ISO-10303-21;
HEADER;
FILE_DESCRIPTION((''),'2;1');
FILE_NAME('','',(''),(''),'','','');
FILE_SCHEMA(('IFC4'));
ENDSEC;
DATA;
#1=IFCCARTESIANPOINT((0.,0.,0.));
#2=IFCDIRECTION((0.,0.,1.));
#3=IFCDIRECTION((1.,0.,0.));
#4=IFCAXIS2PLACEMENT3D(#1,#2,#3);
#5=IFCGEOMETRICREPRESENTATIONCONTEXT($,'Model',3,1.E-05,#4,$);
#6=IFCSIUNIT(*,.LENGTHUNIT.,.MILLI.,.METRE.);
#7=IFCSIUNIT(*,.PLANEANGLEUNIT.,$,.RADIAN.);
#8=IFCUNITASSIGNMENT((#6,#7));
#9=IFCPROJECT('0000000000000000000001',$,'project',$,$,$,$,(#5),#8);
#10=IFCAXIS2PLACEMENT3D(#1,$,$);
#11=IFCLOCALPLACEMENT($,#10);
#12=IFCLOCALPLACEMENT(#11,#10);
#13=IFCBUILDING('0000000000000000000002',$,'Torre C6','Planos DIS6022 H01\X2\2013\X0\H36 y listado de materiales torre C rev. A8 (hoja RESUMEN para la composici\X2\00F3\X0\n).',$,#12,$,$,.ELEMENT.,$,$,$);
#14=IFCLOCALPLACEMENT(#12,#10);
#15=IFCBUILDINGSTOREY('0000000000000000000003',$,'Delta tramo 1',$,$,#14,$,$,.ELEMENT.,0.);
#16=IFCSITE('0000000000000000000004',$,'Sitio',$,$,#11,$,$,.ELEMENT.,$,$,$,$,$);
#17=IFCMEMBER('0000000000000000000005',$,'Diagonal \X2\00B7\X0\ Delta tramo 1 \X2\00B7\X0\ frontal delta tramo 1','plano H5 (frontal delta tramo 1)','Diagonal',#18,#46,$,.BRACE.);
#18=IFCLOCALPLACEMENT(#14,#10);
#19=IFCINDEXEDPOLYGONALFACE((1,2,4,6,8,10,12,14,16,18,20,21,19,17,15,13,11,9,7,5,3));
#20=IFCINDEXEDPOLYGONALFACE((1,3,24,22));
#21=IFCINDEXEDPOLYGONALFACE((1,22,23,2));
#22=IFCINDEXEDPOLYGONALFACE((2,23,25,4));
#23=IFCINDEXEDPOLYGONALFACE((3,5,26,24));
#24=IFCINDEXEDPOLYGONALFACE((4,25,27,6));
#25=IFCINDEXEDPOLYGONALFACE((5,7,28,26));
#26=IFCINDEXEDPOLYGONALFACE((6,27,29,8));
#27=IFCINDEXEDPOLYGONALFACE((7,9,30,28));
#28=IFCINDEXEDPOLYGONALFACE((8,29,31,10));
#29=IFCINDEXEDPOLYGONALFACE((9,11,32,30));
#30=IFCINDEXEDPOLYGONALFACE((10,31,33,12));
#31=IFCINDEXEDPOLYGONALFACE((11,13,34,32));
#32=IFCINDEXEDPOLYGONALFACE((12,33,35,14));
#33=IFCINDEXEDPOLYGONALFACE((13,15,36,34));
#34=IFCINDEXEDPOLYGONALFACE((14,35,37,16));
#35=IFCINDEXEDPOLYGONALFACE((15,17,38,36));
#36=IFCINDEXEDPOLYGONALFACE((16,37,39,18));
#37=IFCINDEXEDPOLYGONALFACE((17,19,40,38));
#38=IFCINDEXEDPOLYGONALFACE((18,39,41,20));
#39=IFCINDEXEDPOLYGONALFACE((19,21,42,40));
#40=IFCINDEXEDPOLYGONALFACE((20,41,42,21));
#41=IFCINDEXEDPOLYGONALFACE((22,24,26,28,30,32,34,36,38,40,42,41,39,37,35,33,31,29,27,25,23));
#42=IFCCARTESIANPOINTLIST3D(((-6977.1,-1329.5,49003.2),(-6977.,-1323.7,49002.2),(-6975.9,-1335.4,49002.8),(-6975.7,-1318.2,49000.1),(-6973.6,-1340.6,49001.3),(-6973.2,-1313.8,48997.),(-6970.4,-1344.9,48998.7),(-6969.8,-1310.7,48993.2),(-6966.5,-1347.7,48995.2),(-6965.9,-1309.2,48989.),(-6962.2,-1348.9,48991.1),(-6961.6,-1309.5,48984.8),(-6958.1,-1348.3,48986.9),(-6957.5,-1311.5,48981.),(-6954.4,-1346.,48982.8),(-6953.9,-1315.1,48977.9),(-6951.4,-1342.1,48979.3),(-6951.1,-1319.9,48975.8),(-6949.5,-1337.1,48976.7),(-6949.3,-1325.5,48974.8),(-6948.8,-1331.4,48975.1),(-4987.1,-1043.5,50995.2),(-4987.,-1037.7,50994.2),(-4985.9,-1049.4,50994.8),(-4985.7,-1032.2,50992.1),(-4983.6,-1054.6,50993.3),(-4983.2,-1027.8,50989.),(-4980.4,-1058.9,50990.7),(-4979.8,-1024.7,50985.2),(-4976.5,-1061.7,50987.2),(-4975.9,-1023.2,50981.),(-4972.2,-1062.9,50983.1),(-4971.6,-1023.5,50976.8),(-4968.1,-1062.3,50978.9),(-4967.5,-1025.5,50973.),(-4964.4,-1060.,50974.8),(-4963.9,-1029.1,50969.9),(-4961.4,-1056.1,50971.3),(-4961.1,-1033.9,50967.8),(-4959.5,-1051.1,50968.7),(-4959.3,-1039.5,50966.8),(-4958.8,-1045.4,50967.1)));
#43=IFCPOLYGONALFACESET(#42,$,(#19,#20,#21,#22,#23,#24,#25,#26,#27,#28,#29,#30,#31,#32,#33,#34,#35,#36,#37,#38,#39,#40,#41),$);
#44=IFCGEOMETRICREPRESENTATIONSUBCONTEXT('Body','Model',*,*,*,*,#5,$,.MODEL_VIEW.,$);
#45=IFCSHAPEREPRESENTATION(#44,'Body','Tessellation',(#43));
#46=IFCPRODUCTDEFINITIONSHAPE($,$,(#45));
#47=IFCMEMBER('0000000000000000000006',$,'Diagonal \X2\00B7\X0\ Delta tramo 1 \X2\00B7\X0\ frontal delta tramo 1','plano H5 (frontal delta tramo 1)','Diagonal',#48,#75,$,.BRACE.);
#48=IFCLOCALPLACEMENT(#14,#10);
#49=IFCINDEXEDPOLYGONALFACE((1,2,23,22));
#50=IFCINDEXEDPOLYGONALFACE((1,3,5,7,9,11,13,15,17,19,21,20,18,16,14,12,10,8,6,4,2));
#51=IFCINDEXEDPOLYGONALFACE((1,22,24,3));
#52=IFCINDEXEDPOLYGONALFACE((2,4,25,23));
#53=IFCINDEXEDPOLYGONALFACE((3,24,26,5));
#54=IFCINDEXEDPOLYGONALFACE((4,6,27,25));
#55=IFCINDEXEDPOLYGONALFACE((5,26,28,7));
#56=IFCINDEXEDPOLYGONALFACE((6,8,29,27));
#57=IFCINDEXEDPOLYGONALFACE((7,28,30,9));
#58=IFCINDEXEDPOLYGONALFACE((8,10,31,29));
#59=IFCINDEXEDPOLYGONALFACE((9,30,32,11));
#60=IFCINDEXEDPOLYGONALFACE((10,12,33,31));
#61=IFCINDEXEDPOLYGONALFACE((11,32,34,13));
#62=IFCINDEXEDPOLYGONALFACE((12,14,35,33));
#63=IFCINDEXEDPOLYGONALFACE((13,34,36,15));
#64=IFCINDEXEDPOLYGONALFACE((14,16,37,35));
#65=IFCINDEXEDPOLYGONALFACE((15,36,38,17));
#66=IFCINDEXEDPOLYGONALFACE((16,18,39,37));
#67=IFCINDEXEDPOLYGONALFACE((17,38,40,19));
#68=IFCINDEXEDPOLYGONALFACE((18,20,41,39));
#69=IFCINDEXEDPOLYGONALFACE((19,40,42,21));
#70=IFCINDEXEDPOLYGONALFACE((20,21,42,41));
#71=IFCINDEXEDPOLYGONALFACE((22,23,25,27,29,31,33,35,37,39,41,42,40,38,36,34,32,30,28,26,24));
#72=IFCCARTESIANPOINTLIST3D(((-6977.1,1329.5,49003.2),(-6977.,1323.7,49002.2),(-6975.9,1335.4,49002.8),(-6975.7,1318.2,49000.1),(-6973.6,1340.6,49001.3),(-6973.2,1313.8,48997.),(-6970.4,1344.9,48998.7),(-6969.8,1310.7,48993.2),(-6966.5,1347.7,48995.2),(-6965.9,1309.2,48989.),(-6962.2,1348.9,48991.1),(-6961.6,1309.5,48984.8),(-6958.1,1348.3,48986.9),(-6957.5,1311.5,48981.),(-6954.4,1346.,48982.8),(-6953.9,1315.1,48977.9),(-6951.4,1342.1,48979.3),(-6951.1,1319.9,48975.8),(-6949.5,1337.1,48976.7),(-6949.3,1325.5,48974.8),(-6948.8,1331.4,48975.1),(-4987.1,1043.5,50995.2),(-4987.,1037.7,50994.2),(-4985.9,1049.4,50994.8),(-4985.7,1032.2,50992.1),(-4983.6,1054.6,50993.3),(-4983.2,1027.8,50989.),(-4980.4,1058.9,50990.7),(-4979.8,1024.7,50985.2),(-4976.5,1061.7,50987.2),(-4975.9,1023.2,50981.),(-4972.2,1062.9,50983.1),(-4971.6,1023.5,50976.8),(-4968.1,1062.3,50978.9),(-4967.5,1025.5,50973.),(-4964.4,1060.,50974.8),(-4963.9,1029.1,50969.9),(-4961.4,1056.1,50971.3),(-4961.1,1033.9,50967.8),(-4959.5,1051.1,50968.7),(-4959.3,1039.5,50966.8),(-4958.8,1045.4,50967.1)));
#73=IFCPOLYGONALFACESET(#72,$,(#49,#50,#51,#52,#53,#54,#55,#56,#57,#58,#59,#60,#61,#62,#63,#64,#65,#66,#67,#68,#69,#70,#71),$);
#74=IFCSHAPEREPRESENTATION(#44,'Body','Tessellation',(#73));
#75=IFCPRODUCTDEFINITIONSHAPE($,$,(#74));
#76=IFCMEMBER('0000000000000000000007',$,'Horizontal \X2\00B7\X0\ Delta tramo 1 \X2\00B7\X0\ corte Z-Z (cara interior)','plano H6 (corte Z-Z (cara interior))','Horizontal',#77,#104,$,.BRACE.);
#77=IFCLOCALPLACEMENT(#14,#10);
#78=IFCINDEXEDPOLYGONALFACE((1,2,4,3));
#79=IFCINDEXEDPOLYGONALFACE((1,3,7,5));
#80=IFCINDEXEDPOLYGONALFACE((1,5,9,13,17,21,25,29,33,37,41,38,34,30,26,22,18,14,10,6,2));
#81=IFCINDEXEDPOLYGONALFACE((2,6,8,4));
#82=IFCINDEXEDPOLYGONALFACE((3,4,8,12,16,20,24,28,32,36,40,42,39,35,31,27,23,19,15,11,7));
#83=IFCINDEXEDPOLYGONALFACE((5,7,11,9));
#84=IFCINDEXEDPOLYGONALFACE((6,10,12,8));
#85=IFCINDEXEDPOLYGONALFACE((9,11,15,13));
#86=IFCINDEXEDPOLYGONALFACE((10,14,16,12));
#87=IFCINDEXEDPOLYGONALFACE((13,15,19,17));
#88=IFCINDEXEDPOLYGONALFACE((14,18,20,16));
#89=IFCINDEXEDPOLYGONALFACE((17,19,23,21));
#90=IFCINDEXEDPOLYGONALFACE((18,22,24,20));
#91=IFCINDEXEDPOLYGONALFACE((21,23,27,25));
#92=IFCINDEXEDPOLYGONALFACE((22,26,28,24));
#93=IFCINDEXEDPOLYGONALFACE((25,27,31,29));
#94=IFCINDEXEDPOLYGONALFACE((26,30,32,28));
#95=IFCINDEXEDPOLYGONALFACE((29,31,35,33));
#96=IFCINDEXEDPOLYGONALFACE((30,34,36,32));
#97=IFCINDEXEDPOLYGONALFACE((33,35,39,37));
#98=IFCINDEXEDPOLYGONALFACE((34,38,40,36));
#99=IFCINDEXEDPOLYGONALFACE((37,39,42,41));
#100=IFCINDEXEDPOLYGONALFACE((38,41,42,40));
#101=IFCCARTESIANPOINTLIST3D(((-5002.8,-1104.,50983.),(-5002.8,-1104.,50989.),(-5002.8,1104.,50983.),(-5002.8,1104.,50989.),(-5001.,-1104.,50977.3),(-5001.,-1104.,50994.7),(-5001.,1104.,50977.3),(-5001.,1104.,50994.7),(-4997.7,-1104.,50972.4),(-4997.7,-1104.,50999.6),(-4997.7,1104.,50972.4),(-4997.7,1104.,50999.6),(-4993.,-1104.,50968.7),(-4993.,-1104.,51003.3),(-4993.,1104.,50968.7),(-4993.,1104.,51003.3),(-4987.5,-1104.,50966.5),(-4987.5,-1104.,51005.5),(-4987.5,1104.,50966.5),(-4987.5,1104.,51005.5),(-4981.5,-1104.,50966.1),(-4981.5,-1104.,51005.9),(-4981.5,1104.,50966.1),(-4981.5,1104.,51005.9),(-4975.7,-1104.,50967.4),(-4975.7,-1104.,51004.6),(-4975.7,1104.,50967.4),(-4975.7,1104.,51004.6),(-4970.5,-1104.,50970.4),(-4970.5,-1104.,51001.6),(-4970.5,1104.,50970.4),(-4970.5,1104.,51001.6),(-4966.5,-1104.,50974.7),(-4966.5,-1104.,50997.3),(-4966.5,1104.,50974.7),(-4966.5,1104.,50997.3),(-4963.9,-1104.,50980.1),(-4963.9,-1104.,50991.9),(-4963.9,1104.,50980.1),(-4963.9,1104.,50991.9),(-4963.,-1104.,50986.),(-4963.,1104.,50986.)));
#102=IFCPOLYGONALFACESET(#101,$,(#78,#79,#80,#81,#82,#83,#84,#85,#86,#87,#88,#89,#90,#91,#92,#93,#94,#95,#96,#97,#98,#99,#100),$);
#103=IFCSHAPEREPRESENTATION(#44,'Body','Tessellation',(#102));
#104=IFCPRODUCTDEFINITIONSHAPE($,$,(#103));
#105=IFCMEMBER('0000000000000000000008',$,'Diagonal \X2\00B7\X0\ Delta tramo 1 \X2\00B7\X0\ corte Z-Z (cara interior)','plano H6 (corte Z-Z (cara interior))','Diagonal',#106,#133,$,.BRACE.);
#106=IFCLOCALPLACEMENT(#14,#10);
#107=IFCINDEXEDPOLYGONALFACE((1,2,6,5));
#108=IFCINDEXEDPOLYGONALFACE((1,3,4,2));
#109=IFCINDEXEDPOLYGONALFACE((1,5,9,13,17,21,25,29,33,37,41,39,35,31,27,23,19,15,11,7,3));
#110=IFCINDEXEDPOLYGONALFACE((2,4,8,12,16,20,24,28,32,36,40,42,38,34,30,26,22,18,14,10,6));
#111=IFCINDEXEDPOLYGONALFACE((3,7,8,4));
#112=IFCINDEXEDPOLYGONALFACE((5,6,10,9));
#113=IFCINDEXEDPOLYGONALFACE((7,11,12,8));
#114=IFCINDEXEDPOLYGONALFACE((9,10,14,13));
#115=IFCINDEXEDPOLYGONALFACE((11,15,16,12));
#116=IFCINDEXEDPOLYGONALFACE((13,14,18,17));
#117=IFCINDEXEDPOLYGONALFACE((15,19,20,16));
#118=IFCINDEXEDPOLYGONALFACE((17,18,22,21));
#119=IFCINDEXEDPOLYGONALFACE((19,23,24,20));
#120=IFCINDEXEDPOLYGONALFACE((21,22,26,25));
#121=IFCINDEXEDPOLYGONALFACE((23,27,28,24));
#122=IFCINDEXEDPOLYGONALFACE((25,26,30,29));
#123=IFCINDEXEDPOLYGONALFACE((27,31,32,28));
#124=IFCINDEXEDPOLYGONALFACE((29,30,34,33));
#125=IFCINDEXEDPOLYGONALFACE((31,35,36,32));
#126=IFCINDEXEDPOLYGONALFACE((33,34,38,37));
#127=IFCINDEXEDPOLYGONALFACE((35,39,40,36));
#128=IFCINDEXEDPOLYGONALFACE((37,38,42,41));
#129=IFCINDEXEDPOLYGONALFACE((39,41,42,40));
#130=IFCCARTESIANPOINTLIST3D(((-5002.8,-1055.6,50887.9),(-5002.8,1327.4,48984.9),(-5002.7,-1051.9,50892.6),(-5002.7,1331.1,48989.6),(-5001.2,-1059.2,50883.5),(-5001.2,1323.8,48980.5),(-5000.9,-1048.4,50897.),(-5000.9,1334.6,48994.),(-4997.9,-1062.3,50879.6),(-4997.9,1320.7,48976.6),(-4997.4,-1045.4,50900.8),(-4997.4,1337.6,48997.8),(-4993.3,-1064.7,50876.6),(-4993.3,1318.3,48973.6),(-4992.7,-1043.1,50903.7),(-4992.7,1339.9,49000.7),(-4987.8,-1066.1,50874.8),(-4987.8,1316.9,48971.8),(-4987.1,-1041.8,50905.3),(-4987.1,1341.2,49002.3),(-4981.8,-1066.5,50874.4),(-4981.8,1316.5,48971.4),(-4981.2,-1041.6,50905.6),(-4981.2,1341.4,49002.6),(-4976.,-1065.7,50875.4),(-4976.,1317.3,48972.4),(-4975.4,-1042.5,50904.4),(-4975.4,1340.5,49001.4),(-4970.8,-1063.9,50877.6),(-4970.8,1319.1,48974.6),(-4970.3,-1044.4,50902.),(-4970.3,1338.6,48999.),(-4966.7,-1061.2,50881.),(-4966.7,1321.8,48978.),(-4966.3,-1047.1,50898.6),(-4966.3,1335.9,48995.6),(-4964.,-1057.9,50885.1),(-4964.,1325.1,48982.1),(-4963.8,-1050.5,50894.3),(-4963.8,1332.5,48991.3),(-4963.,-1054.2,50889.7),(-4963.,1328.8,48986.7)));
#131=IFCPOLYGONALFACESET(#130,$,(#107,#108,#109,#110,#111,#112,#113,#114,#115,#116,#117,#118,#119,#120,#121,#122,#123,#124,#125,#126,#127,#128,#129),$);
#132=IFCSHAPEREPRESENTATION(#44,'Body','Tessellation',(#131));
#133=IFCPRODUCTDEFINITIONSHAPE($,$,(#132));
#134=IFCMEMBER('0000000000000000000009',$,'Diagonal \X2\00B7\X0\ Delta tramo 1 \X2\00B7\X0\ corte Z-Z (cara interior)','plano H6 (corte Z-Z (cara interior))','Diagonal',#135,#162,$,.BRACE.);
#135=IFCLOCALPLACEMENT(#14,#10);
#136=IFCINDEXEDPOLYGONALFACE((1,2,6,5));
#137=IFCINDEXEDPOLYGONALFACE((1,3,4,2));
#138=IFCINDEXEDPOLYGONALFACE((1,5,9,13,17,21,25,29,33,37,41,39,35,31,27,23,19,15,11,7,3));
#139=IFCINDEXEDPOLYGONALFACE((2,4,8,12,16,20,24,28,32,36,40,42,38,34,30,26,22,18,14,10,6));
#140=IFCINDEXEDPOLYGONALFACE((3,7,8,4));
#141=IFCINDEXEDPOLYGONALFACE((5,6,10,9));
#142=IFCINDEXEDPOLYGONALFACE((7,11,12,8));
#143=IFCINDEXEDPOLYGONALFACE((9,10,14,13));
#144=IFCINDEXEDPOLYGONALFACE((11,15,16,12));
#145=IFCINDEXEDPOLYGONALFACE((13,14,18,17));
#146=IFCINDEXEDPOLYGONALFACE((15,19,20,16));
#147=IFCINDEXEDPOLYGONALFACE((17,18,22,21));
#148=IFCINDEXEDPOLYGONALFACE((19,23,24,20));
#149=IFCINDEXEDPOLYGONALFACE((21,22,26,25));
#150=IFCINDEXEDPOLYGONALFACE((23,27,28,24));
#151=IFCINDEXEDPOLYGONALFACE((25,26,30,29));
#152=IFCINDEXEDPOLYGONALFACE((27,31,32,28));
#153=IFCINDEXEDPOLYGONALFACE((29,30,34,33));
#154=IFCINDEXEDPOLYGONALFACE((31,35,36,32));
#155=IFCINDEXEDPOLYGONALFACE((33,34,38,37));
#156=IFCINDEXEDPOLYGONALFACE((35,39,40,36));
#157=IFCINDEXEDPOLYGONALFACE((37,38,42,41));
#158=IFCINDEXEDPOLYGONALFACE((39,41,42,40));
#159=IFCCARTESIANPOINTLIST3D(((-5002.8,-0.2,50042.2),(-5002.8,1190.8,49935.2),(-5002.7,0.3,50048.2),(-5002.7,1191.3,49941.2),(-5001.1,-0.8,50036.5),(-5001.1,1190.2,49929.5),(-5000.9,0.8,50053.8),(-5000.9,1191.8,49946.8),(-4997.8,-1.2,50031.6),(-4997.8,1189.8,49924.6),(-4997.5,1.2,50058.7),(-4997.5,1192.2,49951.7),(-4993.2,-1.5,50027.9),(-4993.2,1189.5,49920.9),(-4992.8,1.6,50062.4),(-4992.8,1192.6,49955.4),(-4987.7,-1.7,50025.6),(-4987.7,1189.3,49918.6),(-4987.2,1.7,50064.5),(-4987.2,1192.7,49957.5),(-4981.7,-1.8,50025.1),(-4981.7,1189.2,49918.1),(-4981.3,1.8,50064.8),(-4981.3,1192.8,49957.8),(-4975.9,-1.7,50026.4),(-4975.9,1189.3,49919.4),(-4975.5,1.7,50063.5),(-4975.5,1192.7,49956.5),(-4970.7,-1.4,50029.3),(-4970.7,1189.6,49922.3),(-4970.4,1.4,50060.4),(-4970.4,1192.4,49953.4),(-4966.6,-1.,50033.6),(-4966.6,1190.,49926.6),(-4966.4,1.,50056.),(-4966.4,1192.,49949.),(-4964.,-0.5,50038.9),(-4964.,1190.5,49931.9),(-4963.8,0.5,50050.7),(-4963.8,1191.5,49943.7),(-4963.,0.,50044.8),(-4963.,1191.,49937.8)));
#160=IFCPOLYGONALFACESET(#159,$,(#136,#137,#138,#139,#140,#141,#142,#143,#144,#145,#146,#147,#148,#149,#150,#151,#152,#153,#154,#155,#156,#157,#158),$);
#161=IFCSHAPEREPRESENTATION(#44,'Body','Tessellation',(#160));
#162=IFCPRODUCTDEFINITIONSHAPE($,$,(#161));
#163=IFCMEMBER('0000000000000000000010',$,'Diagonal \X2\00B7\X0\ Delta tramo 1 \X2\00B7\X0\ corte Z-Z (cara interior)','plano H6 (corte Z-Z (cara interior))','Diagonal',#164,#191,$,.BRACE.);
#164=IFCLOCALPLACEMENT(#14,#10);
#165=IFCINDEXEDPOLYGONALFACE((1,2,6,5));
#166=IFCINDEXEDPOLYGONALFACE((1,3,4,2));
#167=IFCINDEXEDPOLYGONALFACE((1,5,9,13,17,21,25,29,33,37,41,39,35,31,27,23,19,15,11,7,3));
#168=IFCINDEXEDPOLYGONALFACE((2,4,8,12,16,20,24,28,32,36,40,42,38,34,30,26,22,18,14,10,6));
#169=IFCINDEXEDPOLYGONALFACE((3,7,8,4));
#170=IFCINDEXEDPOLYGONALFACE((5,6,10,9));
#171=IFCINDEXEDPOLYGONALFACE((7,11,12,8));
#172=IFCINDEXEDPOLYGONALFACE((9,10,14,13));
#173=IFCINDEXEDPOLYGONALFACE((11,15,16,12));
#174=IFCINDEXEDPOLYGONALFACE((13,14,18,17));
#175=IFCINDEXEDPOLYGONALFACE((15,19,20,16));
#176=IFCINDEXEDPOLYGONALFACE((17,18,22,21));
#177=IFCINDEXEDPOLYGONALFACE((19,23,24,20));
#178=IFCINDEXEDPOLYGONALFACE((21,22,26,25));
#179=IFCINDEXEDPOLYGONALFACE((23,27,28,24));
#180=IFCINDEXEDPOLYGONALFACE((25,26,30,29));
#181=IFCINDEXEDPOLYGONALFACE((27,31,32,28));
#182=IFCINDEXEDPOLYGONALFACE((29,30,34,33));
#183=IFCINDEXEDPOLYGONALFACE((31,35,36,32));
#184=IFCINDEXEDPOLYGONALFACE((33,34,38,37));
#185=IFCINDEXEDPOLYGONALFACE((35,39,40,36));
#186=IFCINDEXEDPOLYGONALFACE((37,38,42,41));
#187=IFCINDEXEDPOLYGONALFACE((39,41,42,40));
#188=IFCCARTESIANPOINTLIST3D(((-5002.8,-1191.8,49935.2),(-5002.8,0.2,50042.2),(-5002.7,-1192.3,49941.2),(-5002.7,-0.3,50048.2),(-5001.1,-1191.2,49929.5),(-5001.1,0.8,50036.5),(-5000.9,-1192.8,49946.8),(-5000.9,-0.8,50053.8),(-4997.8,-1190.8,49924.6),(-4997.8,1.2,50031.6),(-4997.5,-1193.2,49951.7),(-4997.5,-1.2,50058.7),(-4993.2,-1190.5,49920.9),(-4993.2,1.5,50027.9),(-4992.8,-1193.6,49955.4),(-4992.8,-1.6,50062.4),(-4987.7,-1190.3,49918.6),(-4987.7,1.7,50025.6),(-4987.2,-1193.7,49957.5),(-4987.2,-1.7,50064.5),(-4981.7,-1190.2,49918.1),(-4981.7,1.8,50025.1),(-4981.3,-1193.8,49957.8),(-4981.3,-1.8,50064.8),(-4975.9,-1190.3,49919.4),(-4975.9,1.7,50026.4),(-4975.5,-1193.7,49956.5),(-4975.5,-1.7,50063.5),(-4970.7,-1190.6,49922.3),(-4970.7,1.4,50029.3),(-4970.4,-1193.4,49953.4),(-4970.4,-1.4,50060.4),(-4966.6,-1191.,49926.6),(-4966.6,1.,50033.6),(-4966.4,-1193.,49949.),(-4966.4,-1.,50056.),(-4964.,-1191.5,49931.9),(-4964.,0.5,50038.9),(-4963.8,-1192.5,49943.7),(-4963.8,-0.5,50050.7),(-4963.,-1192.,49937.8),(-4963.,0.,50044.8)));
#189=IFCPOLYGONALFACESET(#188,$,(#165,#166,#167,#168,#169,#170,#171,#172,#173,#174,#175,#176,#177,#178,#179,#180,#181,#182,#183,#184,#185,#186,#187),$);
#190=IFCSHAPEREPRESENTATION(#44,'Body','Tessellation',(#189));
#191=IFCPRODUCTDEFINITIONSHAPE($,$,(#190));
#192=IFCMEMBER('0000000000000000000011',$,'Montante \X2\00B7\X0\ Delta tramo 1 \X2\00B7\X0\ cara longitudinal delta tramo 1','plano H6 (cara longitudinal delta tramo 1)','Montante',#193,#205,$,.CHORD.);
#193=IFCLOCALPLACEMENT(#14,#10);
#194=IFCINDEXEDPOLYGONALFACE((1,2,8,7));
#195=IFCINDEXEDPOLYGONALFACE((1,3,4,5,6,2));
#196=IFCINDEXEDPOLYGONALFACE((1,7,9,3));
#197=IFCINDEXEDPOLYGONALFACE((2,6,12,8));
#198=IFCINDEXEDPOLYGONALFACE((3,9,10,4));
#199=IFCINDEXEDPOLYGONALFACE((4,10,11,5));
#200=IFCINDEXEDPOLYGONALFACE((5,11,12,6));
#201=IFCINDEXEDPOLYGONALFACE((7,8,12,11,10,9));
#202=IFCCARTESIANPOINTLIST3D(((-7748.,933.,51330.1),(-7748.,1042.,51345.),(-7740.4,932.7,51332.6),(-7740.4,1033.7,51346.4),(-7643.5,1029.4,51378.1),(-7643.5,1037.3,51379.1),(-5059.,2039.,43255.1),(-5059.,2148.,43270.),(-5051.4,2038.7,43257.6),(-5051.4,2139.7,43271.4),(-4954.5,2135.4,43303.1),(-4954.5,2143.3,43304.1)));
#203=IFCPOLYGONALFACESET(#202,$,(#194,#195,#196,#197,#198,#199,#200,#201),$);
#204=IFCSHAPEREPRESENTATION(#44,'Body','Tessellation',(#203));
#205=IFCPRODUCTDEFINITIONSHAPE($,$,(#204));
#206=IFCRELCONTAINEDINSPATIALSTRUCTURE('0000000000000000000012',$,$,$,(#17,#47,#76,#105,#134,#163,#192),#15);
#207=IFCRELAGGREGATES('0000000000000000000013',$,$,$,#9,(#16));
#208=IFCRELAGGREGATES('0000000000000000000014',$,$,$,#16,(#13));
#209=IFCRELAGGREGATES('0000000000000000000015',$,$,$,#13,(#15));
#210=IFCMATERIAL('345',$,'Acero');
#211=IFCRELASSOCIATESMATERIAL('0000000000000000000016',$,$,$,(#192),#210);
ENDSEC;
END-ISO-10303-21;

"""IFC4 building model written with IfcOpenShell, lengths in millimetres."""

from ifc_helpers import new_model, si_unit, frame, frame_2d, origin, origin_with_axes, place, context, subcontext, project, spatial, circle, l_section, extrude, material, element, save


model = new_model("IFC4")

# Units and contexts
model_context = context("Model", 3, precision=1e-05, world=origin_with_axes())
body_context = subcontext(model_context, "Body", "Model", "MODEL_VIEW")
ifc_project = project(units=[si_unit("LENGTHUNIT", "METRE", prefix="MILLI"), si_unit("PLANEANGLEUNIT", "RADIAN")], contexts=[model_context])

# Site, building, storey
site_placement = place(None, origin())
site = spatial("IfcSite", under=ifc_project, at=site_placement, Name="Sitio", CompositionType="ELEMENT")
building_placement = place(site_placement, origin())
building = spatial("IfcBuilding", under=site, at=building_placement, Name="Torre C6", Description="Planos DIS6022 H01–H36 y listado de materiales torre C rev. A8 (hoja RESUMEN para la composición).", CompositionType="ELEMENT")
storey_placement = place(building_placement, origin())
storey = spatial("IfcBuildingStorey", under=building, at=storey_placement, Name="Delta tramo 1", CompositionType="ELEMENT", Elevation=0.0)

# Members
ifc_material = material(Name="345", Category="Acero")
for number, where, z_axis, x_axis, name in (
    (1, (-4973.0, -1043.0, 50981.0), (-0.703134, -0.101053, -0.70384), (0.683901, 0.174833, -0.708316), "Diagonal · Delta tramo 1 · frontal delta tramo 1"),
    (2, (-4973.0, 1043.0, 50981.0), (-0.703134, 0.101053, -0.70384), (0.683901, -0.174833, -0.708316), "Diagonal · Delta tramo 1 · frontal delta tramo 1"),
):
    element("IfcMember", number, at=place(storey_placement, frame(where, z_axis=z_axis, x_axis=x_axis)), inside=storey, Name=name, Description="plano H5 (frontal delta tramo 1)", ObjectType="Diagonal", PredefinedType="BRACE", context=body_context, shape_type="SweptSolid", body=[
        extrude(circle(Radius=20.0), None, (0.0, 0.0, 1.0), 2830.2),
    ])
member_1_placement = place(storey_placement, frame((-4983.0, -1104.0, 50986.0), z_axis=(0.0, 1.0, 0.0), x_axis=(1.0, 0.0, 0.0)))
element("IfcMember", 3, at=member_1_placement, inside=storey, Name="Horizontal · Delta tramo 1 · corte Z-Z (cara interior)", Description="plano H6 (corte Z-Z (cara interior))", ObjectType="Horizontal", PredefinedType="BRACE", context=body_context, shape_type="SweptSolid", body=[
    extrude(circle(Radius=20.0), None, (0.0, 0.0, 1.0), 2208.0),
])
member_2_placement = place(storey_placement, frame((-4983.0, -1054.0, 50890.0), z_axis=(0.0, 0.781412, -0.624015), x_axis=(0.999852, -0.010743, -0.013453)))
element("IfcMember", 4, at=member_2_placement, inside=storey, Name="Diagonal · Delta tramo 1 · corte Z-Z (cara interior)", Description="plano H6 (corte Z-Z (cara interior))", ObjectType="Diagonal", PredefinedType="BRACE", context=body_context, shape_type="SweptSolid", body=[
    extrude(circle(Radius=20.0), None, (0.0, 0.0, 1.0), 3049.6),
])
member_3_placement = place(storey_placement, frame((-4983.0, 1191.0, 49938.0), z_axis=(0.0, -0.995989, 0.08948), x_axis=(0.999943, -0.000957, -0.01065)))
element("IfcMember", 5, at=member_3_placement, inside=storey, Name="Diagonal · Delta tramo 1 · corte Z-Z (cara interior)", Description="plano H6 (corte Z-Z (cara interior))", ObjectType="Diagonal", PredefinedType="BRACE", context=body_context, shape_type="SweptSolid", body=[
    extrude(circle(Radius=20.0), None, (0.0, 0.0, 1.0), 1195.8),
])
member_4_placement = place(storey_placement, frame((-4983.0, -1192.0, 49938.0), z_axis=(0.0, 0.995995, 0.089406), x_axis=(0.999943, 0.000956, -0.01065)))
element("IfcMember", 6, at=member_4_placement, inside=storey, Name="Diagonal · Delta tramo 1 · corte Z-Z (cara interior)", Description="plano H6 (corte Z-Z (cara interior))", ObjectType="Diagonal", PredefinedType="BRACE", context=body_context, shape_type="SweptSolid", body=[
    extrude(circle(Radius=20.0), None, (0.0, 0.0, 1.0), 1196.8),
])
member_5_placement = place(storey_placement, frame((-7748.0, 1042.0, 51345.0), z_axis=(0.313311, 0.128867, -0.940866), x_axis=(0.94965, -0.042516, 0.310413)))
element("IfcMember", 7, at=member_5_placement, inside=storey, material=ifc_material, Name="Montante · Delta tramo 1 · cara longitudinal delta tramo 1", Description="plano H6 (cara longitudinal delta tramo 1)", ObjectType="Montante", PredefinedType="CHORD", context=body_context, shape_type="SweptSolid", body=[
    extrude(l_section(Depth=110.0, Width=110.0, Thickness=8.0, at=frame_2d((55.0, 55.0))), None, (0.0, 0.0, 1.0), 8582.5),
])

save(model, "model.ifc")
